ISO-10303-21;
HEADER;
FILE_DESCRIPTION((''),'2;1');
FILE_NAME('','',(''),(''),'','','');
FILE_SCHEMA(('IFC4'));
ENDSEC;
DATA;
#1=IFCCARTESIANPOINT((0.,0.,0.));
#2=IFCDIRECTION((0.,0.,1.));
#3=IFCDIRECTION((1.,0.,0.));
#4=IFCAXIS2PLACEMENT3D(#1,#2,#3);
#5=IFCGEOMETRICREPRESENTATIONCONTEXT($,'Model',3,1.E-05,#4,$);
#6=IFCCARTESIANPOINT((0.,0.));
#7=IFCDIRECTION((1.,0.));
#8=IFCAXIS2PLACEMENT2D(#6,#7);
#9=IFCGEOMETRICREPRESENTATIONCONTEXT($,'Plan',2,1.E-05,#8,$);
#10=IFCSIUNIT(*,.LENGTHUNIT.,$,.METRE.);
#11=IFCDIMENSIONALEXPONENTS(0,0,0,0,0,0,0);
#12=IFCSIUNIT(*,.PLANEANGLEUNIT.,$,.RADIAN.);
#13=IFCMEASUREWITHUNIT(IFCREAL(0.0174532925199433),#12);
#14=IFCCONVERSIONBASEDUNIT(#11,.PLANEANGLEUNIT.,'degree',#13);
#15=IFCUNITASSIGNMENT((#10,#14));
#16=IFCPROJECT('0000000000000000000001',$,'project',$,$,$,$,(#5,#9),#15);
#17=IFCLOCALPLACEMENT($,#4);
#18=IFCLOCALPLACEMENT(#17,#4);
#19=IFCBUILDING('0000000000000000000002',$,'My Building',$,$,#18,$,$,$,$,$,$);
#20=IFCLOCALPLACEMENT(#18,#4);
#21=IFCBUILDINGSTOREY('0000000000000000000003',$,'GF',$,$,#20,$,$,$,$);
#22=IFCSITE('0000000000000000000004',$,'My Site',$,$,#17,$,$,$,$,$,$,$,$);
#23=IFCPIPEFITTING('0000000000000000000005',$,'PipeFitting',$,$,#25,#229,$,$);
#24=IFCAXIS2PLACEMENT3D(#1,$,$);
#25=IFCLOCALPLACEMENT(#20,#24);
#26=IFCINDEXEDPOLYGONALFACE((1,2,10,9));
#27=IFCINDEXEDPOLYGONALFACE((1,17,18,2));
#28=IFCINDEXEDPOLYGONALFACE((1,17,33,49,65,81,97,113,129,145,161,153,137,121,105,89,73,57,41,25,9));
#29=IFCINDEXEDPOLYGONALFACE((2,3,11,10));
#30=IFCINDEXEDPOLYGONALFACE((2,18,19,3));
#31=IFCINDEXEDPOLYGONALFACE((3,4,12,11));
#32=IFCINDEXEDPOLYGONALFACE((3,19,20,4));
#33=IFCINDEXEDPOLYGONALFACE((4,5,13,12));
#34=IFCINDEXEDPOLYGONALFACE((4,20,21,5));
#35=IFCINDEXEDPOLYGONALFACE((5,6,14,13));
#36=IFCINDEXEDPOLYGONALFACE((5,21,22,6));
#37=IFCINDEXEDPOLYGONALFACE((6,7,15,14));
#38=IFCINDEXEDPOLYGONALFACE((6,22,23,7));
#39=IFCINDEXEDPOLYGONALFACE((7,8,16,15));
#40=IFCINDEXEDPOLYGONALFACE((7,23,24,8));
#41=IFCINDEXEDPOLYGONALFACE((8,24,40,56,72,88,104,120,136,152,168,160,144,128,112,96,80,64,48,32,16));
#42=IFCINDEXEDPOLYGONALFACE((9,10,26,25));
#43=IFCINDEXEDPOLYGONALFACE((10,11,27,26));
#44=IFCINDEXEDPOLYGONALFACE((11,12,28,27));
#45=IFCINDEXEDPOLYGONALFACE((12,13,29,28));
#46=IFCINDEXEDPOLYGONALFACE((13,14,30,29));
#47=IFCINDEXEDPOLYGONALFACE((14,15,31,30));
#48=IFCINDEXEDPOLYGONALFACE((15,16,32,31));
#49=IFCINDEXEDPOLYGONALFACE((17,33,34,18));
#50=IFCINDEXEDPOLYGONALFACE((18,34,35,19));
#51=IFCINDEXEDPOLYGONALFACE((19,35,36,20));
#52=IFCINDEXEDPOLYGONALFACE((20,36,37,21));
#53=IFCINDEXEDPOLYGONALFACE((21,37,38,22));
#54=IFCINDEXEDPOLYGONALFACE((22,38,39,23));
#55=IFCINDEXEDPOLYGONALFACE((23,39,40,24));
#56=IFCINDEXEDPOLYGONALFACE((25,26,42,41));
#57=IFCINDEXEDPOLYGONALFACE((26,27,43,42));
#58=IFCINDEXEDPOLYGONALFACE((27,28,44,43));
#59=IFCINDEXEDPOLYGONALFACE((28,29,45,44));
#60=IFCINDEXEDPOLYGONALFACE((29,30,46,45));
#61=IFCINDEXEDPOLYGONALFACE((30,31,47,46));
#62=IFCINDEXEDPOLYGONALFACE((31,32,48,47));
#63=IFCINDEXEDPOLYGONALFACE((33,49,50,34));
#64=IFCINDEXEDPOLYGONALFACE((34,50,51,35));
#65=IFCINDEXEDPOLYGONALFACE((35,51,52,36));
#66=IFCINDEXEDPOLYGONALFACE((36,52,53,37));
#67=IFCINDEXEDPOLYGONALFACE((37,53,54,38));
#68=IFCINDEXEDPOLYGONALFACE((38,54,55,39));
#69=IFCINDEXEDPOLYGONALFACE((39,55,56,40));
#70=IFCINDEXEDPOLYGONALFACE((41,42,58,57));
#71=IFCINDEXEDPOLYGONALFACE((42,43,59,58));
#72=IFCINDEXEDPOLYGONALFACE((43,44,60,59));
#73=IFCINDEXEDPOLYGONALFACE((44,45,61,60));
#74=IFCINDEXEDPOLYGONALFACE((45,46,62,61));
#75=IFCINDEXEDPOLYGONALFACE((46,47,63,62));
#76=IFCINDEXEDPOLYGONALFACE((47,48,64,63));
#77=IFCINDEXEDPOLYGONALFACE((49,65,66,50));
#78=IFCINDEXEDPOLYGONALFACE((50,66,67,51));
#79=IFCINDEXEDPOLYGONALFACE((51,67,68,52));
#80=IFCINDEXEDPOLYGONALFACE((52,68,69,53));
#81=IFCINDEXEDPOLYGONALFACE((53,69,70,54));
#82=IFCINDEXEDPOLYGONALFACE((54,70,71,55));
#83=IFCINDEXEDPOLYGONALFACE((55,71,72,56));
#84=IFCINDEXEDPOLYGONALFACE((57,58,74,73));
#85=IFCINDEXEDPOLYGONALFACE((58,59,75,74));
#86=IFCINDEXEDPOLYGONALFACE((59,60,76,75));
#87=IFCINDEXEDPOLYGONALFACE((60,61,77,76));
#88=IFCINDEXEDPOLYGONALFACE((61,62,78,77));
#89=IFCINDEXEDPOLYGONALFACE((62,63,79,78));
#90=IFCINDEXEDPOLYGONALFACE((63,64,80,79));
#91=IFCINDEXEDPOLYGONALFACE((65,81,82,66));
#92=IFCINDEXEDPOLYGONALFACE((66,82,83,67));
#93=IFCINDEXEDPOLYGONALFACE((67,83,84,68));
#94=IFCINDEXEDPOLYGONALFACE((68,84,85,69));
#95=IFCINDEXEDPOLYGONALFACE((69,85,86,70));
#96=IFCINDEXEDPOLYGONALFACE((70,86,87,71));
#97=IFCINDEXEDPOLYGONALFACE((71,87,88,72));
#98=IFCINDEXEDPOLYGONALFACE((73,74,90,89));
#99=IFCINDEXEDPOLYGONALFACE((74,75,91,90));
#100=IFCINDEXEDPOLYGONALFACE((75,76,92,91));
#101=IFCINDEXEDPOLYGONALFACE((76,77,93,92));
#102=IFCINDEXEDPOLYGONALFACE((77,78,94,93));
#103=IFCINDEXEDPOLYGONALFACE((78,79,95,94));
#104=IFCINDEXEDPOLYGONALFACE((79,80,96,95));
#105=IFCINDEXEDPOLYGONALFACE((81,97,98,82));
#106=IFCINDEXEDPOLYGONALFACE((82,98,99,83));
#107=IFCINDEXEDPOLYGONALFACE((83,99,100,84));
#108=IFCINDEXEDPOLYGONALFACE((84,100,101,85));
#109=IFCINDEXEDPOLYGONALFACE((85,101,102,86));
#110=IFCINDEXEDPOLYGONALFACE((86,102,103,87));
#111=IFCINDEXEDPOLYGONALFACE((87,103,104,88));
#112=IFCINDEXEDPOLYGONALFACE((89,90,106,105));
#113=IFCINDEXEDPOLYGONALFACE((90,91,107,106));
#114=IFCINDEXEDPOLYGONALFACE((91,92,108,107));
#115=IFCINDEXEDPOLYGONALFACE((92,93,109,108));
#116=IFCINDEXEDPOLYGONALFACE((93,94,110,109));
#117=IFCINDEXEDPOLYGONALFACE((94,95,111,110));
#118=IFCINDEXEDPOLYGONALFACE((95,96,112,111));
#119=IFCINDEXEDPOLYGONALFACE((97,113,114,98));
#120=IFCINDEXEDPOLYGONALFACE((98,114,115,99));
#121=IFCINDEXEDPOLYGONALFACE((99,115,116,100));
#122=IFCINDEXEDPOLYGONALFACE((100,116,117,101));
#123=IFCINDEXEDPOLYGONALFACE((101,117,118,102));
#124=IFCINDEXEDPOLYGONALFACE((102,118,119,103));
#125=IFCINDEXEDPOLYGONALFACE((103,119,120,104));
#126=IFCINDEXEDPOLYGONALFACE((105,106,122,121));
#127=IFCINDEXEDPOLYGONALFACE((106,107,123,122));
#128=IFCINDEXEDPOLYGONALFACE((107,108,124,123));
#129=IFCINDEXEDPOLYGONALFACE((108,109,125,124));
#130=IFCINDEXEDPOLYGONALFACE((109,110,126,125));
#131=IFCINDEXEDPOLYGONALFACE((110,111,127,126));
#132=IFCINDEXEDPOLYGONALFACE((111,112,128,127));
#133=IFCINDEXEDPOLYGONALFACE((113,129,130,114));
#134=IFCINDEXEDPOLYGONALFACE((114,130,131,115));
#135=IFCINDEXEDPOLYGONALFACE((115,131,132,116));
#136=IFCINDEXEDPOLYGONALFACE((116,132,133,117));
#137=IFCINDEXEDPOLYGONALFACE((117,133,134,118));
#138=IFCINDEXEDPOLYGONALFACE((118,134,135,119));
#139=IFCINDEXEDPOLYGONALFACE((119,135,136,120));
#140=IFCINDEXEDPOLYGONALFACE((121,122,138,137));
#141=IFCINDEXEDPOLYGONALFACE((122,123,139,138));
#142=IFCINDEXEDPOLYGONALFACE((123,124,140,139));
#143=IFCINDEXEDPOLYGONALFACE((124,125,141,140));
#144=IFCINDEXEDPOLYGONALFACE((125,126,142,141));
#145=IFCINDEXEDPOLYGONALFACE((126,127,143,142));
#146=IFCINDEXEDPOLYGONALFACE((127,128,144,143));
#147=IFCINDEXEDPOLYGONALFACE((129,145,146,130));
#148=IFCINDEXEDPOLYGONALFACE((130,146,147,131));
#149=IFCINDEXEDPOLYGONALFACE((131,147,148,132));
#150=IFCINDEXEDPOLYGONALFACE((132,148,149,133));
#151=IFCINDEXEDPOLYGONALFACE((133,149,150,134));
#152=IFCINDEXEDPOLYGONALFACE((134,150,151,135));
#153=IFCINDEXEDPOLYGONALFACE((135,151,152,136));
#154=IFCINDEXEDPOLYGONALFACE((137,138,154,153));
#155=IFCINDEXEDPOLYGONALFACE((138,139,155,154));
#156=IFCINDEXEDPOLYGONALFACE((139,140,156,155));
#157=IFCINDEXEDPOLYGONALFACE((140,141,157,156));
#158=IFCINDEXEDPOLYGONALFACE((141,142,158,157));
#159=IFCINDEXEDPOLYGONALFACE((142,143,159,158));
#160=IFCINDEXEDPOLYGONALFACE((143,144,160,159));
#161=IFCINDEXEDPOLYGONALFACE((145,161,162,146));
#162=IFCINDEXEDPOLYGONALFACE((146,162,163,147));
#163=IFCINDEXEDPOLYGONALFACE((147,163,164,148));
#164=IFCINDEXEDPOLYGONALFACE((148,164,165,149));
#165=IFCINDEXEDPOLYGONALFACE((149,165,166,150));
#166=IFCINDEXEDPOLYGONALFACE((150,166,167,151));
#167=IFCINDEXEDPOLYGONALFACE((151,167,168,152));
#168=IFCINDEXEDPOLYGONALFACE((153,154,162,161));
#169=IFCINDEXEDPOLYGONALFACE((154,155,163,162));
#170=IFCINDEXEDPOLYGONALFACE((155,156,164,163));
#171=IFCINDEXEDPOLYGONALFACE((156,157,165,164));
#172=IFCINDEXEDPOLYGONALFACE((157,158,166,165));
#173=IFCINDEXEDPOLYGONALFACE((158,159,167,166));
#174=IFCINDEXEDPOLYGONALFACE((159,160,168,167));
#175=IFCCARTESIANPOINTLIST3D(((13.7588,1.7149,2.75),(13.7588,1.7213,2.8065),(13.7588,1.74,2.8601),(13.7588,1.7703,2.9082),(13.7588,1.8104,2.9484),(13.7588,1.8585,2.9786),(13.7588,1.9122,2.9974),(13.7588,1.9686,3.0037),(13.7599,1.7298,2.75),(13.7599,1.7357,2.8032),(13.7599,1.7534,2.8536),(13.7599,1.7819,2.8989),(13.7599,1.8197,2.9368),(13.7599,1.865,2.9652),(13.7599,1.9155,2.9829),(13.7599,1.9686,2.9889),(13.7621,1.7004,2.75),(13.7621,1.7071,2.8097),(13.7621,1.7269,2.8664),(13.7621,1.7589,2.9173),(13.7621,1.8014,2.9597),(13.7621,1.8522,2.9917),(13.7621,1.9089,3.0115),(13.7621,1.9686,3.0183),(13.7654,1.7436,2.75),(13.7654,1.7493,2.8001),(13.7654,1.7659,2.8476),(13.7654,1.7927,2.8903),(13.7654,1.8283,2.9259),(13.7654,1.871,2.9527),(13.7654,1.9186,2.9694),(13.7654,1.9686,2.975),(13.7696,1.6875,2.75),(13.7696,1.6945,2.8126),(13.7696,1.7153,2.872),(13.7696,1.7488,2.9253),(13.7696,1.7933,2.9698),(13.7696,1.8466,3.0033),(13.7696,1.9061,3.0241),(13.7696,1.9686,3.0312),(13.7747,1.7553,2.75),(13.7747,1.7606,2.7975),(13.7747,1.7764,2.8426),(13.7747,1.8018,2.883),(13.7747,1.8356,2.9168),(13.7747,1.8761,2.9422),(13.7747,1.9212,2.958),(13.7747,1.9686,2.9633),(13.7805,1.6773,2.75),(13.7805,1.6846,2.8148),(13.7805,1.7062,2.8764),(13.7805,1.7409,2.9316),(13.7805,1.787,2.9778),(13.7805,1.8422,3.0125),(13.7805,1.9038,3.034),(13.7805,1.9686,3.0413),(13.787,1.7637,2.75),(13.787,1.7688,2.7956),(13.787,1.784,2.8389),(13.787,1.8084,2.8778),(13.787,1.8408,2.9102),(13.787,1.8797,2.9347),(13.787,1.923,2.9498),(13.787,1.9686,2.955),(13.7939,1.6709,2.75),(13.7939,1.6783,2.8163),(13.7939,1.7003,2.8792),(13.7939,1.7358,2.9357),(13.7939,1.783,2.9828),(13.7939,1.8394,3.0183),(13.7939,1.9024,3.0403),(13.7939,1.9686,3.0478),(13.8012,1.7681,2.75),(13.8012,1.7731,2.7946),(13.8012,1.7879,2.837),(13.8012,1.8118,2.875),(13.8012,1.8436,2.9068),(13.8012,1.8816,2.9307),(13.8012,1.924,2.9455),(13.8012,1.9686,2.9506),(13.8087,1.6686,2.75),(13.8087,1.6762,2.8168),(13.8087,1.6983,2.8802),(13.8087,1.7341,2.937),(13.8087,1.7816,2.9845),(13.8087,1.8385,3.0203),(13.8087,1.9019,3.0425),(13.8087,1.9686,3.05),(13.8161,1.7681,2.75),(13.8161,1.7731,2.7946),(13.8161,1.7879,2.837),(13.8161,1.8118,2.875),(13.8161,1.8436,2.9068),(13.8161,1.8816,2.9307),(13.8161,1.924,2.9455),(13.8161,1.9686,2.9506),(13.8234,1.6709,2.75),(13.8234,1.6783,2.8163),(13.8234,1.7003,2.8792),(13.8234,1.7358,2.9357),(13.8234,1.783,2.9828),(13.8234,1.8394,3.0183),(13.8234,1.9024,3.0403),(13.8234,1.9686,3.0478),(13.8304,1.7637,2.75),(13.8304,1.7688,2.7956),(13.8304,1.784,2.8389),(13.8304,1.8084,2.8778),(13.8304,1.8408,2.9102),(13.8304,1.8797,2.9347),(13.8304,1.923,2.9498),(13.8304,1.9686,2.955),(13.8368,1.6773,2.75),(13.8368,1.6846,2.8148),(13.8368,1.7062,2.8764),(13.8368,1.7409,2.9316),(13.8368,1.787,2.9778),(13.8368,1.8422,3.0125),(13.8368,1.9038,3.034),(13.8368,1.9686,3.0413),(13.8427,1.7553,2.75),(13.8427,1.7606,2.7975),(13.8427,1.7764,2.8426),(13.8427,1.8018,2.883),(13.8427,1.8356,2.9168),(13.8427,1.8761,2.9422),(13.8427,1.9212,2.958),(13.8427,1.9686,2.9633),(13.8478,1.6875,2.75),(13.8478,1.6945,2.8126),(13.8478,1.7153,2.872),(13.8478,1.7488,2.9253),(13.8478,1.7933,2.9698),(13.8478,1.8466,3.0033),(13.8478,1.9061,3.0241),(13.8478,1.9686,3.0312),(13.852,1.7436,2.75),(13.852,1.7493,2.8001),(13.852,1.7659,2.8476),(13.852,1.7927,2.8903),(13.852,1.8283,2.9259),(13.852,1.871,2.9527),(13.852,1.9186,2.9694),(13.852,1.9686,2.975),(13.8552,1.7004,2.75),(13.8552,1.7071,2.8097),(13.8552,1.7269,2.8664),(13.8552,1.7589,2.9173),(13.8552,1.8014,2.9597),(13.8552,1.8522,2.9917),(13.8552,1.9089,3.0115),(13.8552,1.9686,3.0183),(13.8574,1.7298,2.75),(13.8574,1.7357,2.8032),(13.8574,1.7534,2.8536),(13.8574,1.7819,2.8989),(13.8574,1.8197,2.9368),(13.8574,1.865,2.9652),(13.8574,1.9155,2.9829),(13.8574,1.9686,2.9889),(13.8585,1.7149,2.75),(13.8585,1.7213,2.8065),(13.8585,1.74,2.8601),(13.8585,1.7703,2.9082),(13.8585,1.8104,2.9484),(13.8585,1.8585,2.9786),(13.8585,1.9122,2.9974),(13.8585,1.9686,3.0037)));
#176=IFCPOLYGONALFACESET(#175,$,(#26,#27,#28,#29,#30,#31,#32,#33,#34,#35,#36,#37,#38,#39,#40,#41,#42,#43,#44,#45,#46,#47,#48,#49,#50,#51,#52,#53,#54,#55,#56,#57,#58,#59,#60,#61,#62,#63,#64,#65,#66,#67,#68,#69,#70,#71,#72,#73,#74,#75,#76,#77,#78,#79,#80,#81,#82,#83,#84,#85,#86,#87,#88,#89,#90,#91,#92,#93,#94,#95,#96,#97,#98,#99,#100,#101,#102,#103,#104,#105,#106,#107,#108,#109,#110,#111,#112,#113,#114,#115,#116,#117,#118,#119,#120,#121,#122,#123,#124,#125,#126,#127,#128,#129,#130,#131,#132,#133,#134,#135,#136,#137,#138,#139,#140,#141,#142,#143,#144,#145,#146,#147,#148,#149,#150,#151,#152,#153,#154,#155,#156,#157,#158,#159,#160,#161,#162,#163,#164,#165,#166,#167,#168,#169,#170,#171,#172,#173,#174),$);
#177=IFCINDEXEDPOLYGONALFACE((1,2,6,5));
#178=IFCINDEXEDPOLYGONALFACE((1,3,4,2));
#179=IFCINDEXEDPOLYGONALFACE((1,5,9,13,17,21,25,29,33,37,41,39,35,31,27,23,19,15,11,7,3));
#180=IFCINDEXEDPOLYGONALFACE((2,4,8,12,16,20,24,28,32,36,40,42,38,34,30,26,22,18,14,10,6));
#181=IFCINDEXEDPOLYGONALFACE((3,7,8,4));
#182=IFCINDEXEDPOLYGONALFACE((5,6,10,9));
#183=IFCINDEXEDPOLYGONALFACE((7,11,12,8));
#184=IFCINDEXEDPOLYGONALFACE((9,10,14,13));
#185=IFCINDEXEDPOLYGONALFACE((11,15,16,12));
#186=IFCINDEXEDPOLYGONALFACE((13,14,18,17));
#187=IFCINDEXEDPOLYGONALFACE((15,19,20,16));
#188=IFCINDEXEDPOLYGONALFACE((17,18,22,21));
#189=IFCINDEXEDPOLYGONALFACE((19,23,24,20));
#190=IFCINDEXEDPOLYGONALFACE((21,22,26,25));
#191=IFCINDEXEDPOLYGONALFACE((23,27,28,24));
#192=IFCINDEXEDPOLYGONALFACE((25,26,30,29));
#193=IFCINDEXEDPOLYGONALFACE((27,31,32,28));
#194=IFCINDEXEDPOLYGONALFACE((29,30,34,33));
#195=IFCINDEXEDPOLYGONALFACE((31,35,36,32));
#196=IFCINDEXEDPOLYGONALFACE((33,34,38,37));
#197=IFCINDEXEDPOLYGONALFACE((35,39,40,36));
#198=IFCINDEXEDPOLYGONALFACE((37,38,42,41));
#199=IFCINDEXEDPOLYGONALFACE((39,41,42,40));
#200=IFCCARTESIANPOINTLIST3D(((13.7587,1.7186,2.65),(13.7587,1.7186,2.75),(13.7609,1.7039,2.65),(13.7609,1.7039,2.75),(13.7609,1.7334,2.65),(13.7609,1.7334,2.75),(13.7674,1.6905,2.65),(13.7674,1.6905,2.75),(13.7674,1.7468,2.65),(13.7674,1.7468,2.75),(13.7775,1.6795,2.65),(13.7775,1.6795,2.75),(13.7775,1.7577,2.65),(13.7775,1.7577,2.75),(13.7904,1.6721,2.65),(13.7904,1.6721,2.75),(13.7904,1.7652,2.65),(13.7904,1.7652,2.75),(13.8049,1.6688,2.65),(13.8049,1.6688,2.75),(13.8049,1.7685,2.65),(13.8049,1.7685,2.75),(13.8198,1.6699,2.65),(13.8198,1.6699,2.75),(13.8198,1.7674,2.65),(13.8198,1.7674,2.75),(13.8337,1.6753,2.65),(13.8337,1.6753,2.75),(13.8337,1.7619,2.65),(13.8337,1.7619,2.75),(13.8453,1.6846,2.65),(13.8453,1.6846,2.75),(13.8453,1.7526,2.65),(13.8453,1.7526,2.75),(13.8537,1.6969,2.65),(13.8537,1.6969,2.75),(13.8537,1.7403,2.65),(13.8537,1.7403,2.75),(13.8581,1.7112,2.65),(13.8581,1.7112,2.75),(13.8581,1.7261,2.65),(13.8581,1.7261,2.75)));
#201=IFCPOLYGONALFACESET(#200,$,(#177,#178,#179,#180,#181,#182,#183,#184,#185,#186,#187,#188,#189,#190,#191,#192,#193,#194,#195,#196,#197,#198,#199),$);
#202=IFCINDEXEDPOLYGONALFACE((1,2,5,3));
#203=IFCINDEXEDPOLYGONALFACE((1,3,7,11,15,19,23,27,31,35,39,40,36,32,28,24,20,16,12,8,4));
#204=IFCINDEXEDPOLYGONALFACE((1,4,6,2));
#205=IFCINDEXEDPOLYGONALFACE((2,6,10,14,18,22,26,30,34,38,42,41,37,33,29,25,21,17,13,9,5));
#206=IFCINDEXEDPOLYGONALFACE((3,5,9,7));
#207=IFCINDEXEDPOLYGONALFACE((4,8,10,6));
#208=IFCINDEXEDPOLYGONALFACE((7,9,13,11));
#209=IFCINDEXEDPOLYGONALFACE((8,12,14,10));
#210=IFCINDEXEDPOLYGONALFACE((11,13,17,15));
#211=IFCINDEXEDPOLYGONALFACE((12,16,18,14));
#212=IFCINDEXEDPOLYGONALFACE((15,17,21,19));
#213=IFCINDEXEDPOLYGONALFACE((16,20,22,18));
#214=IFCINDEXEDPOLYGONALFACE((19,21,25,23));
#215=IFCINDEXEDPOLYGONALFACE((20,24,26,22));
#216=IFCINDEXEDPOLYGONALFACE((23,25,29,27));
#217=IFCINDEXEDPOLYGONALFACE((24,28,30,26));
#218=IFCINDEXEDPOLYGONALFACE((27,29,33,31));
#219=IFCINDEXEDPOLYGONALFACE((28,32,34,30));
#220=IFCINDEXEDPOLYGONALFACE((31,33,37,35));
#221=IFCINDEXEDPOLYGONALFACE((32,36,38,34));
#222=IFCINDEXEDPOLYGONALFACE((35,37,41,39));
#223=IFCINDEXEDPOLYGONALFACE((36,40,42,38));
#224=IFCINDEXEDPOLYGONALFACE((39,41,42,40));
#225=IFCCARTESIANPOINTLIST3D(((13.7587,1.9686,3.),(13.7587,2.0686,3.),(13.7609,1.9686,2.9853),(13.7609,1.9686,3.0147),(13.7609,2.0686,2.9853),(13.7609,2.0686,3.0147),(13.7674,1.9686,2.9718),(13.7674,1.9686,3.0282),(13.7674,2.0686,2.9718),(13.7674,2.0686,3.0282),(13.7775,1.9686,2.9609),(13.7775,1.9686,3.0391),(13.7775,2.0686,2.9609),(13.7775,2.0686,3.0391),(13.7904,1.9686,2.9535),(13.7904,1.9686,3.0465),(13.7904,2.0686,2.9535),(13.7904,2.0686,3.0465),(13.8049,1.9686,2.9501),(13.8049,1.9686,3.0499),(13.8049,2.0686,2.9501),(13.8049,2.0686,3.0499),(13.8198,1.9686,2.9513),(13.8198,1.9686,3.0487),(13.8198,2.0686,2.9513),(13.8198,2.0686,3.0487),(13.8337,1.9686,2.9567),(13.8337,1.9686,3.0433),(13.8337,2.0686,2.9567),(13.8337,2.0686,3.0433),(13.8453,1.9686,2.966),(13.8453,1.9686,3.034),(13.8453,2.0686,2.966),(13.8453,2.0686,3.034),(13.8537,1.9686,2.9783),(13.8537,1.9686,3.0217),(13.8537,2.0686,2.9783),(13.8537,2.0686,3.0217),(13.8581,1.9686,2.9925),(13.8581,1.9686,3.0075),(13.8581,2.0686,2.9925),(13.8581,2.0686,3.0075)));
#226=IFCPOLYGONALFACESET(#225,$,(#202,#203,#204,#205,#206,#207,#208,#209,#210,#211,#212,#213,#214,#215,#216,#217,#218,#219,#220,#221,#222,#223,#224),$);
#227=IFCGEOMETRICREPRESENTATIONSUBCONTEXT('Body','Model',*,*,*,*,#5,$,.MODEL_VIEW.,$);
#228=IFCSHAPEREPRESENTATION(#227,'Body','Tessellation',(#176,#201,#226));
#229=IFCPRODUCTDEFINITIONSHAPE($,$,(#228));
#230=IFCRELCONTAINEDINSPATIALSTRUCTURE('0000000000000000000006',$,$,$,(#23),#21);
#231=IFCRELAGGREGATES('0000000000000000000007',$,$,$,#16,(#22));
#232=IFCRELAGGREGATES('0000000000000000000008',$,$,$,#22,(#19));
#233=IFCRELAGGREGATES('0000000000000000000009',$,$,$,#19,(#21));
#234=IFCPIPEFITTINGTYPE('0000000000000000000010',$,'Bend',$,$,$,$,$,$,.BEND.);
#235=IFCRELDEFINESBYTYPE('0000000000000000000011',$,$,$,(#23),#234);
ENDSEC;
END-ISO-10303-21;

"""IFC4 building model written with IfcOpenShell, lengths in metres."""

from ifc_helpers import new_model, entity, si_unit, converted_unit, frame, origin_with_axes, origin_2d_with_axis, place, context, subcontext, project, spatial, circle, extrude, source, transform, mapped, type_object, type_shapes, element, save


model = new_model("IFC4")

# Units and contexts
model_context = context("Model", 3, precision=1e-05, world=origin_with_axes())
plan_context = context("Plan", 2, precision=1e-05, world=origin_2d_with_axis())
body_context_1 = subcontext(model_context, "Body", "Model", "MODEL_VIEW")
ifc_project = project(units=[si_unit("LENGTHUNIT", "METRE"), converted_unit("PLANEANGLEUNIT", "degree", entity("IfcReal", 0.0174532925199433), si_unit("PLANEANGLEUNIT", "RADIAN"), dimensions=[0, 0, 0, 0, 0, 0, 0])], contexts=[model_context, plan_context])

# Site, building, storey
site_placement = place(None, origin_with_axes())
site = spatial("IfcSite", under=ifc_project, at=site_placement, Name="My Site")
building_placement = place(site_placement, origin_with_axes())
building = spatial("IfcBuilding", under=site, at=building_placement, Name="My Building")
storey_placement = place(building_placement, origin_with_axes())
storey = spatial("IfcBuildingStorey", under=building, at=storey_placement, Name="GF")

# Pipe fitting
pipe_fitting_type = type_object("IfcPipeFittingType", Name="Bend", PredefinedType="BEND")
shared_shape_1 = source(origin_with_axes(), body_context_1, "Body", "SolidModel", [
    entity("IfcSweptDiskSolid", entity("IfcIndexedPolyCurve", entity("IfcCartesianPointList3D", [[0.0, 0.0, -0.1], [0.0, 0.0732, -0.2768], [0.0, 0.25, -0.35]]), [entity("IfcArcIndex", [1, 2, 3])]), 0.05),
    extrude(circle(Radius=0.05), origin_with_axes(), (0.0, 0.0, -1.0), 0.1),
    extrude(circle(Radius=0.05), frame((0.0, 0.25, -0.35), z_axis=(0.0, 1.0, 0.0), x_axis=(1.0, 0.0, 0.0)), (0.0, 0.0, 1.0), 0.1),
])
type_shapes(pipe_fitting_type, [shared_shape_1])
for number, where, z_axis, x_axis, name in (
    (1, (13.8087, 1.7186, 2.65), (0.0, 0.0, -1.0), (-1.0, 0.0, 0.0), "PipeFitting"),
):
    element("IfcPipeFitting", number, at=place(storey_placement, frame(where, z_axis=z_axis, x_axis=x_axis)), inside=storey, type_object=pipe_fitting_type, Name=name, context=body_context_1, shape_type="MappedRepresentation", body=[
        mapped(shared_shape_1, transform((0.0, 0.0, 0.0), x_axis=(1.0, 0.0, 0.0), y_axis=(0.0, 1.0, 0.0), z_axis=(0.0, 0.0, 1.0), scale=1.0)),
    ])

save(model, "model.ifc")
